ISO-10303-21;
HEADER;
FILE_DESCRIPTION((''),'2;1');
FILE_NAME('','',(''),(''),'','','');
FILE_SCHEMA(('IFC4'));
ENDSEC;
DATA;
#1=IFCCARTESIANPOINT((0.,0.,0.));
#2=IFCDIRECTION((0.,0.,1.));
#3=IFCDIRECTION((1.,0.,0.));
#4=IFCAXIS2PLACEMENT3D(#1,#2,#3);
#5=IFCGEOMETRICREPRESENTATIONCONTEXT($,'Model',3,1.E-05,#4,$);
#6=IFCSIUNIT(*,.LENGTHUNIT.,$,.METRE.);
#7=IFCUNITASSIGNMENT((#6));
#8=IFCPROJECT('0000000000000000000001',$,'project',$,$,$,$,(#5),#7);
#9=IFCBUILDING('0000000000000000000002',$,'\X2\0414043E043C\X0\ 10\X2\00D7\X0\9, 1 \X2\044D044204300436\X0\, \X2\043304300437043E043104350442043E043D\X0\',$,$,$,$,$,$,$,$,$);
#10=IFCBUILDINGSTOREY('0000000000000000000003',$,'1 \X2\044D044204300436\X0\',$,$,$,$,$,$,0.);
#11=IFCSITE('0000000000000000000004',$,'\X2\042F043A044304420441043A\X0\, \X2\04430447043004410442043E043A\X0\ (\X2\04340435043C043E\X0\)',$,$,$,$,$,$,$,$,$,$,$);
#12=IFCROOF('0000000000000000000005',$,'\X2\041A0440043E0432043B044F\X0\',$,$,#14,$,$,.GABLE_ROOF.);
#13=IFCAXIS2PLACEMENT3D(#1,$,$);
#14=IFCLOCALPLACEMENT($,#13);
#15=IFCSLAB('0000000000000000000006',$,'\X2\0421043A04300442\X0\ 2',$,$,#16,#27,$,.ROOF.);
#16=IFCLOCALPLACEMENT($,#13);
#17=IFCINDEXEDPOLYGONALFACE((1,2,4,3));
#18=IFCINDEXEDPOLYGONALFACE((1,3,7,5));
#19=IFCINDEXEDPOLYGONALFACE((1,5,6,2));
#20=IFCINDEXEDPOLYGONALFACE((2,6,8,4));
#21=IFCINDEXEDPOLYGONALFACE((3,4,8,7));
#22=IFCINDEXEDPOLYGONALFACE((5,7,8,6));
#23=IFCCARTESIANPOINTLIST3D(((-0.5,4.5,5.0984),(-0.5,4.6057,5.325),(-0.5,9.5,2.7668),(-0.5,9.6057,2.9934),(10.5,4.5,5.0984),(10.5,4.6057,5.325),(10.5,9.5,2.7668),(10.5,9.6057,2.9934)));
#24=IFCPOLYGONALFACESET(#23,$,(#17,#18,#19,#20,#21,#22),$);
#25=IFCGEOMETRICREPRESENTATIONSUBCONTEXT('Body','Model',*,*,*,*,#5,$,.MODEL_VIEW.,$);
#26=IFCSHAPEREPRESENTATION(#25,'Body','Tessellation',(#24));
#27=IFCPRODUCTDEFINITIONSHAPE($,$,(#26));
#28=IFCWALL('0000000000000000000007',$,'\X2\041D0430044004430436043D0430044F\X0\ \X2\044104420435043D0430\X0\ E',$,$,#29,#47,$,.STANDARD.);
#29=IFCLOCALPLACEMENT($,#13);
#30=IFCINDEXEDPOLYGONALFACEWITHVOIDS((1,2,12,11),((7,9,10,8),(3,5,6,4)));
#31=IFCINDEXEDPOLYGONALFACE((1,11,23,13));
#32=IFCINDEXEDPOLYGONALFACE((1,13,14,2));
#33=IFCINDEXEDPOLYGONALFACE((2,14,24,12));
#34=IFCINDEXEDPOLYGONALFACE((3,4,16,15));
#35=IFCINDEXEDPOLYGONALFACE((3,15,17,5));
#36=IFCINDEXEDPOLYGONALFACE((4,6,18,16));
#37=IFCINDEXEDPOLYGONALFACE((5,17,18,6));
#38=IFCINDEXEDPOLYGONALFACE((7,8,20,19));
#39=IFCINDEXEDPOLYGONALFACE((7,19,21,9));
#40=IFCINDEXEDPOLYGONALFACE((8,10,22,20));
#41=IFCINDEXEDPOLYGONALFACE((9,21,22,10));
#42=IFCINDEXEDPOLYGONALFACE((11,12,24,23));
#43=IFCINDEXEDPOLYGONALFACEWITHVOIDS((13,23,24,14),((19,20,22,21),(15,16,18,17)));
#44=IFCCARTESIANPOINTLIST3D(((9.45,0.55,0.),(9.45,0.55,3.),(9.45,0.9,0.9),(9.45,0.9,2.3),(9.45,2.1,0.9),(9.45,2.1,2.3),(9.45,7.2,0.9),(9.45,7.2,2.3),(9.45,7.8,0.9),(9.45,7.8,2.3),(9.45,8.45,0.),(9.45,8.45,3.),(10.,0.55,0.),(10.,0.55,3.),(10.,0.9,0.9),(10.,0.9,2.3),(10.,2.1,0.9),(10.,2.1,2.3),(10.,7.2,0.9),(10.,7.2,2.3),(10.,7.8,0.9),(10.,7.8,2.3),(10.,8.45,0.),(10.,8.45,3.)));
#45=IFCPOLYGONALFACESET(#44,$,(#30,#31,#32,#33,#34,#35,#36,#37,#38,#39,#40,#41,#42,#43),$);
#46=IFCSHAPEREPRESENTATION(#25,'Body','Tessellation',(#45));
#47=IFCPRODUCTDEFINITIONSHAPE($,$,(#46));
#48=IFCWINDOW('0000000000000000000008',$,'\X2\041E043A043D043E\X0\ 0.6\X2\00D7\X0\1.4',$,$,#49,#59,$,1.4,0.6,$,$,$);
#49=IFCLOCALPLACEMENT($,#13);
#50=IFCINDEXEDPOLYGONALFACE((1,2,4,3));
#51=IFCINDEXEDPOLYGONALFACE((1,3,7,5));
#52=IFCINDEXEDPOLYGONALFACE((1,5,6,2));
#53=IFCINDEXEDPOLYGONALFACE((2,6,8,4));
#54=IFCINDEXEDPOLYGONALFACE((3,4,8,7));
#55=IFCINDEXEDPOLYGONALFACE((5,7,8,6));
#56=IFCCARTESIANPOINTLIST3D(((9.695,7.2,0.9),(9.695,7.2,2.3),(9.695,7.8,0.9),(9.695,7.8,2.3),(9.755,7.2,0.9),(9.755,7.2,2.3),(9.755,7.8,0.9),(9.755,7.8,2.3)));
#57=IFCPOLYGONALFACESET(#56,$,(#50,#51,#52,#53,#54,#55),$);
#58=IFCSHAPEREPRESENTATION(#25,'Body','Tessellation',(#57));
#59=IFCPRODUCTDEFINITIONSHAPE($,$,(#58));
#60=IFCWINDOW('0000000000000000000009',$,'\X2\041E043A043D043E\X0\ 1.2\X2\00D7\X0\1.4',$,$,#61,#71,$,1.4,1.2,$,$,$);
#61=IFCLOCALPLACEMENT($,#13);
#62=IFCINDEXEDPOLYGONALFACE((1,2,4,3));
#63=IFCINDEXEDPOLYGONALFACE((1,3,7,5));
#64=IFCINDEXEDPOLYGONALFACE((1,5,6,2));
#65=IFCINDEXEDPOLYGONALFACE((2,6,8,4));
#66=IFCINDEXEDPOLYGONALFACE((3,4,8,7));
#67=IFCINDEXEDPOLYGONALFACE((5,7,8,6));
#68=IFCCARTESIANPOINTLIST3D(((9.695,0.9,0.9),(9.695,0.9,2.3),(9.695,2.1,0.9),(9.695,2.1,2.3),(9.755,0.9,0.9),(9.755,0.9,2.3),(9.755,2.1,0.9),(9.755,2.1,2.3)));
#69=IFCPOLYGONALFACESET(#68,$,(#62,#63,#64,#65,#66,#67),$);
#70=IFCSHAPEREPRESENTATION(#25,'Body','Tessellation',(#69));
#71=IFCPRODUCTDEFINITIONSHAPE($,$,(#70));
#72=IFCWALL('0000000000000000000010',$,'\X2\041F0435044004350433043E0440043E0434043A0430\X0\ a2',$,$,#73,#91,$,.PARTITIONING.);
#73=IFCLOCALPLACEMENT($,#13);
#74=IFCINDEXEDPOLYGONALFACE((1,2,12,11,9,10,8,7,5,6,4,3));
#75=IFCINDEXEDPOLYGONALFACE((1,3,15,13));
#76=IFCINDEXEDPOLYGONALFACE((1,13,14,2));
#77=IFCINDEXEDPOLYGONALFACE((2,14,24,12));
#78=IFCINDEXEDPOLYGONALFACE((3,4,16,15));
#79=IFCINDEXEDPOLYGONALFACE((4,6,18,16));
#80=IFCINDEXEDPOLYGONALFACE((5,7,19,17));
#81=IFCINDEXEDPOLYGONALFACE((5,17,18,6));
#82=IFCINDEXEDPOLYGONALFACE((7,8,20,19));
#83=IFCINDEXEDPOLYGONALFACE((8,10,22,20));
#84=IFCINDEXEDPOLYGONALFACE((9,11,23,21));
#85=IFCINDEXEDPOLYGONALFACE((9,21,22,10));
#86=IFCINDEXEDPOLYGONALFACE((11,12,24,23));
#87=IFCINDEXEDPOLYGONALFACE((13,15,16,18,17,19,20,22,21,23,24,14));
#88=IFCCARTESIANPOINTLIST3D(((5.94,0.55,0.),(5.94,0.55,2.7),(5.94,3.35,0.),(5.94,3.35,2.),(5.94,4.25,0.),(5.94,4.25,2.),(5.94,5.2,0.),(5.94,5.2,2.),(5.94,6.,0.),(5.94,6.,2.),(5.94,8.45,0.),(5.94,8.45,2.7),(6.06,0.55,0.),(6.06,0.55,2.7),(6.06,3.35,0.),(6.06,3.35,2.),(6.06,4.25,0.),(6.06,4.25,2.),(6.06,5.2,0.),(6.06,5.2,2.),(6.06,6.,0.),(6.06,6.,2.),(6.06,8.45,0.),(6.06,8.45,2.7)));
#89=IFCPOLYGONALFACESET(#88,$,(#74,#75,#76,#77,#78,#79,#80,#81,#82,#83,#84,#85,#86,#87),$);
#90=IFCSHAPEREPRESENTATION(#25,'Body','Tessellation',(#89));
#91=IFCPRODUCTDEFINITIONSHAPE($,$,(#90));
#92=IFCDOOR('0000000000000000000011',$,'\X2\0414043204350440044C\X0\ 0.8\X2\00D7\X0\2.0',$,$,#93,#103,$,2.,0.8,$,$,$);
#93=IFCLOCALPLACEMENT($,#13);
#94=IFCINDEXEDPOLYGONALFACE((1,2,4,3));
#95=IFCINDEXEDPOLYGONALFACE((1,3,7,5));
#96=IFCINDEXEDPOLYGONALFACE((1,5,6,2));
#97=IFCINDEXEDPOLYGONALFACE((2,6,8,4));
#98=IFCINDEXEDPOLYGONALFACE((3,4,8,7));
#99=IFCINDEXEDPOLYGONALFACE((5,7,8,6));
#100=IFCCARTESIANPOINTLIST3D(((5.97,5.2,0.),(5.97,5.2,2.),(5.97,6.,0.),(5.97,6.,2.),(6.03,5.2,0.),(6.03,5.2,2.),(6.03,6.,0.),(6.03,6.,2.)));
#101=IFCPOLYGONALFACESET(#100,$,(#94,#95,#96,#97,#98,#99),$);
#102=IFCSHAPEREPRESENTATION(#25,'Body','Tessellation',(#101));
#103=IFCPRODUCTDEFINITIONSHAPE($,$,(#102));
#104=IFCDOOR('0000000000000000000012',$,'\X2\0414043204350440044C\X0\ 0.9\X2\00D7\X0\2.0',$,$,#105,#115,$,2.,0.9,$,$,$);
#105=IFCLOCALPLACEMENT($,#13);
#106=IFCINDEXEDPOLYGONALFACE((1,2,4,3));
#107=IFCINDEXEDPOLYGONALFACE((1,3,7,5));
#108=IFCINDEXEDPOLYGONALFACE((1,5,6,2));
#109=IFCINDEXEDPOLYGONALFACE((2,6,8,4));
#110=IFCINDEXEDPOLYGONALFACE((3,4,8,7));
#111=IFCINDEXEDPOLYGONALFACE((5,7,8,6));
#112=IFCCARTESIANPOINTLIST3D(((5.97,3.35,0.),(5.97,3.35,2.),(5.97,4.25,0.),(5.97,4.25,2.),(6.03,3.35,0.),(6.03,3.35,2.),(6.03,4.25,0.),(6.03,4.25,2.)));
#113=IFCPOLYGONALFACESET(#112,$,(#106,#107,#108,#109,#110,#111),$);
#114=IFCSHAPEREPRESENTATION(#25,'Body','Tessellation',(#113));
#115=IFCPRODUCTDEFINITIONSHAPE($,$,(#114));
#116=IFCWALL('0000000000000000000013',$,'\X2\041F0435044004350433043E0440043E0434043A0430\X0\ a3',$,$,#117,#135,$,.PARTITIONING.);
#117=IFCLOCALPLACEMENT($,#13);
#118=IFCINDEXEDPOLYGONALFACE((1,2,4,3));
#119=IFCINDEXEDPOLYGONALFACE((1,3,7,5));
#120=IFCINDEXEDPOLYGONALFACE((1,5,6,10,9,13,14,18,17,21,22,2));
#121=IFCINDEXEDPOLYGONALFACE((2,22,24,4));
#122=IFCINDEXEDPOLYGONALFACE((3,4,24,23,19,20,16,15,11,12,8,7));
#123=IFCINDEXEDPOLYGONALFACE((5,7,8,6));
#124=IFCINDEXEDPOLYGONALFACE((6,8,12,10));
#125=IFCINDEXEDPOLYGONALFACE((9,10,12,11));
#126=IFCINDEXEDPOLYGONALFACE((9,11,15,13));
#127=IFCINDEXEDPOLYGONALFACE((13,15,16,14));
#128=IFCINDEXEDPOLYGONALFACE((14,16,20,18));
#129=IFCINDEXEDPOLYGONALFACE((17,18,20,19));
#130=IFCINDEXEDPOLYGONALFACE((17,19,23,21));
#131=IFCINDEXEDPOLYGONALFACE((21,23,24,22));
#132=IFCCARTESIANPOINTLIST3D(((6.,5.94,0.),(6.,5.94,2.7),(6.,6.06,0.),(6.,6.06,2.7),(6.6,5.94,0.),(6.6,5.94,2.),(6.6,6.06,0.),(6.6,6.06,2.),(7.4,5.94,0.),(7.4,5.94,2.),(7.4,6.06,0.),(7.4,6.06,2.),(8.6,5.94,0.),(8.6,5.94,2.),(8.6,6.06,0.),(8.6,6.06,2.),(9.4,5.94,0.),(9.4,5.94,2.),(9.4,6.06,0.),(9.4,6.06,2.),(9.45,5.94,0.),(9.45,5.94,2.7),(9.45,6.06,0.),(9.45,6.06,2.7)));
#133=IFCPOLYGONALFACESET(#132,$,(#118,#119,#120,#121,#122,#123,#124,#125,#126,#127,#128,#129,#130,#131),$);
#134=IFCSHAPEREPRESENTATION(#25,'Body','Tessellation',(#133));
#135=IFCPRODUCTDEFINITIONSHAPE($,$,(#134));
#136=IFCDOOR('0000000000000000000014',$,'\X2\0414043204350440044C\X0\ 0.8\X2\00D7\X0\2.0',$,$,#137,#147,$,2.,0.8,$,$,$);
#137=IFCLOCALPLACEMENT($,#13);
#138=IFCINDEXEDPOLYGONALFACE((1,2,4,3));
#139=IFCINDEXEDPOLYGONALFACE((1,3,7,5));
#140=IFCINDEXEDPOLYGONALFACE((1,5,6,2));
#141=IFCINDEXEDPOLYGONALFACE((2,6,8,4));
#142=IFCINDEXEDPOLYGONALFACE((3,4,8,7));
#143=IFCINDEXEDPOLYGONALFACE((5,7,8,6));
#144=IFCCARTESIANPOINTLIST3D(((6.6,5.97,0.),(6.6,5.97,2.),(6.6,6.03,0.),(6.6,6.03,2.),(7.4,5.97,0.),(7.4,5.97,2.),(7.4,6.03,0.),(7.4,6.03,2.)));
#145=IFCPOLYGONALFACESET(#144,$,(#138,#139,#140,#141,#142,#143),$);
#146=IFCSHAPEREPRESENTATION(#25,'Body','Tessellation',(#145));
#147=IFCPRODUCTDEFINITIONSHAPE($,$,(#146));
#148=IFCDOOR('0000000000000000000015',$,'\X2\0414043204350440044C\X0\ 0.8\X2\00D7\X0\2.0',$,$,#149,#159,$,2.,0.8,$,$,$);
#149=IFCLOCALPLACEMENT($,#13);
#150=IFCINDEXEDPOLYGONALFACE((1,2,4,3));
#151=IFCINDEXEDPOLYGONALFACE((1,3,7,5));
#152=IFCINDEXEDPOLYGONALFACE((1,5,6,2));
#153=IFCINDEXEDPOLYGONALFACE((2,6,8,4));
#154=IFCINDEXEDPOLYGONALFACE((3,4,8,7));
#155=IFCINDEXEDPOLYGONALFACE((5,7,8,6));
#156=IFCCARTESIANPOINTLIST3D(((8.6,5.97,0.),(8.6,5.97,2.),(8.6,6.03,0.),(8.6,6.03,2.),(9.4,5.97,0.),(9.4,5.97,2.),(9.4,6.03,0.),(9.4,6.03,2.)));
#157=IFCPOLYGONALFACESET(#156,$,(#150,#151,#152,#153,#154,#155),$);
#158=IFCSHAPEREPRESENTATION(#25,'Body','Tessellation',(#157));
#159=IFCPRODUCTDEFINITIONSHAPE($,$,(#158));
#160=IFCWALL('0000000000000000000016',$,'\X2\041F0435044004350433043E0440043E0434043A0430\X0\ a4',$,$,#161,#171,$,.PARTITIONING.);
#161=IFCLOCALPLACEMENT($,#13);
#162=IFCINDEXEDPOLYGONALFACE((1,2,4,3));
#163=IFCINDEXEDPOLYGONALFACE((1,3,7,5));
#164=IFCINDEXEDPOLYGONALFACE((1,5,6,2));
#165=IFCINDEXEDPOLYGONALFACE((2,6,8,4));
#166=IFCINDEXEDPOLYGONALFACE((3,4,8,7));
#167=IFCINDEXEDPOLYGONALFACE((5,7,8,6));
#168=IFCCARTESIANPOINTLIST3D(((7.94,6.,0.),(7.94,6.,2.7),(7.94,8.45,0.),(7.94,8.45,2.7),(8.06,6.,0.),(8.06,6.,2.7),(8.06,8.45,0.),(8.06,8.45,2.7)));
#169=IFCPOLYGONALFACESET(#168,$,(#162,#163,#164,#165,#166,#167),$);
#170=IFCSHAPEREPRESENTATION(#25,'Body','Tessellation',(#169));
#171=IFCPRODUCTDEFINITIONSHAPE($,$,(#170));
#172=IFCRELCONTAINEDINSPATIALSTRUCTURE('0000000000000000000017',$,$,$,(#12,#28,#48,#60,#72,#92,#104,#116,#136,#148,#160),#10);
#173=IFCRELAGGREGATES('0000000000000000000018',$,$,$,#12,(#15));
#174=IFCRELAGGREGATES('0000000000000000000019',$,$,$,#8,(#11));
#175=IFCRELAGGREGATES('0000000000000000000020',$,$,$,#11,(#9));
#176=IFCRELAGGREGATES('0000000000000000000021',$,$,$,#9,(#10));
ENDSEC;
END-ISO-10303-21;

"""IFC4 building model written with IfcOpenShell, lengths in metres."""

from ifc_helpers import new_model, si_unit, frame, origin_with_axes, place, context, subcontext, project, spatial, indexed_curve, outline, extrude, element, fill, aggregate, save


model = new_model("IFC4")

# Units and contexts
model_context = context("Model", 3, precision=1e-05, world=origin_with_axes())
body_context = subcontext(model_context, "Body", "Model", "MODEL_VIEW")
ifc_project = project(units=[si_unit("LENGTHUNIT", "METRE")], contexts=[model_context])

# Site, building, storey
site = spatial("IfcSite", under=ifc_project, Name="Якутск, участок (демо)")
building = spatial("IfcBuilding", under=site, Name="Дом 10×9, 1 этаж, газобетон")
storey = spatial("IfcBuildingStorey", under=building, Name="1 этаж", Elevation=0.0)

# Roof, slab
roof = element("IfcRoof", 1, inside=storey, Name="Кровля", PredefinedType="GABLE_ROOF")
slab_placement = place(None, frame((10.5, 9.5, 2.7668), z_axis=(0.0, 0.422618, 0.906308), x_axis=(-1.0, 0.0, 0.0)))
slab = element("IfcSlab", 2, at=slab_placement, Name="Скат 2", PredefinedType="ROOF", context=body_context, shape_type="SweptSolid", body=[
    extrude(outline(indexed_curve([(0.0, 0.0), (11.0, 0.0), (11.0, 5.5169), (0.0, 5.5169)])), None, (0.0, 0.0, 1.0), 0.25),
])
aggregate(roof, [slab])

# Wall, openings, windows
wall_1_placement = place(None, frame((10.0, 0.55, 0.0), z_axis=(0.0, 0.0, 1.0), x_axis=(0.0, 1.0, 0.0)))
wall_1 = element("IfcWall", 3, at=wall_1_placement, inside=storey, Name="Наружная стена E", PredefinedType="STANDARD", context=body_context, shape_type="SweptSolid", body=[
    extrude(outline(indexed_curve([(0.0, 0.0), (0.0, 0.55), (7.9, 0.55), (7.9, 0.0), (0.0, 0.0)], self_intersect=False)), origin_with_axes(), (0.0, 0.0, 1.0), 3.0),
])
opening_1_placement = place(wall_1_placement, frame((6.65, 0.6, 0.9), z_axis=(0.0, 0.0, 1.0), x_axis=(0.0, -1.0, 0.0)))
opening_1 = element("IfcOpeningElement", 4, at=opening_1_placement, cuts=wall_1, context=body_context, shape_type="SweptSolid", body=[
    extrude(outline(indexed_curve([(0.0, 0.0), (0.0, 0.6), (0.65, 0.6), (0.65, 0.0), (0.0, 0.0)], self_intersect=False)), origin_with_axes(), (0.0, 0.0, 1.0), 1.4),
])
opening_2_placement = place(wall_1_placement, frame((0.35, -0.05, 0.9), z_axis=(0.0, 0.0, 1.0), x_axis=(1.0, 0.0, 0.0)))
opening_2 = element("IfcOpeningElement", 5, at=opening_2_placement, cuts=wall_1, context=body_context, shape_type="SweptSolid", body=[
    extrude(outline(indexed_curve([(0.0, 0.0), (0.0, 0.65), (1.2, 0.65), (1.2, 0.0), (0.0, 0.0)], self_intersect=False)), origin_with_axes(), (0.0, 0.0, 1.0), 1.4),
])
window_1_placement = place(opening_1_placement, frame((0.355, 0.0, 0.0), z_axis=(0.0, 0.0, 1.0), x_axis=(0.0, 1.0, 0.0)))
window_1 = element("IfcWindow", 6, at=window_1_placement, inside=storey, Name="Окно 0.6×1.4", OverallHeight=1.4, OverallWidth=0.6, context=body_context, shape_type="SweptSolid", body=[
    extrude(outline(indexed_curve([(0.0, 0.0), (0.0, 0.06), (0.6, 0.06), (0.6, 0.0), (0.0, 0.0)], self_intersect=False)), origin_with_axes(), (0.0, 0.0, 1.0), 1.4),
])
fill(opening_1, window_1)
window_2_placement = place(opening_2_placement, frame((0.0, 0.295, 0.0), z_axis=(0.0, 0.0, 1.0), x_axis=(1.0, 0.0, 0.0)))
window_2 = element("IfcWindow", 7, at=window_2_placement, inside=storey, Name="Окно 1.2×1.4", OverallHeight=1.4, OverallWidth=1.2, context=body_context, shape_type="SweptSolid", body=[
    extrude(outline(indexed_curve([(0.0, 0.0), (0.0, 0.06), (1.2, 0.06), (1.2, 0.0), (0.0, 0.0)], self_intersect=False)), origin_with_axes(), (0.0, 0.0, 1.0), 1.4),
])
fill(opening_2, window_2)

# Walls, openings, doors
wall_2_placement = place(None, frame((6.06, 0.55, 0.0), z_axis=(0.0, 0.0, 1.0), x_axis=(0.0, 1.0, 0.0)))
wall_2 = element("IfcWall", 8, at=wall_2_placement, inside=storey, Name="Перегородка a2", PredefinedType="PARTITIONING", context=body_context, shape_type="SweptSolid", body=[
    extrude(outline(indexed_curve([(0.0, 0.0), (0.0, 0.12), (7.9, 0.12), (7.9, 0.0), (0.0, 0.0)], self_intersect=False)), origin_with_axes(), (0.0, 0.0, 1.0), 2.7),
])
opening_3_placement = place(wall_2_placement, frame((4.65, -0.05, 0.0), z_axis=(0.0, 0.0, 1.0), x_axis=(1.0, 0.0, 0.0)))
opening_3 = element("IfcOpeningElement", 9, at=opening_3_placement, cuts=wall_2, context=body_context, shape_type="SweptSolid", body=[
    extrude(outline(indexed_curve([(0.0, 0.0), (0.0, 0.22), (0.8, 0.22), (0.8, 0.0), (0.0, 0.0)], self_intersect=False)), origin_with_axes(), (0.0, 0.0, 1.0), 2.0),
])
opening_4_placement = place(wall_2_placement, frame((2.8, -0.05, 0.0), z_axis=(0.0, 0.0, 1.0), x_axis=(1.0, 0.0, 0.0)))
opening_4 = element("IfcOpeningElement", 10, at=opening_4_placement, cuts=wall_2, context=body_context, shape_type="SweptSolid", body=[
    extrude(outline(indexed_curve([(0.0, 0.0), (0.0, 0.22), (0.9, 0.22), (0.9, 0.0), (0.0, 0.0)], self_intersect=False)), origin_with_axes(), (0.0, 0.0, 1.0), 2.0),
])
door_1_placement = place(opening_3_placement, frame((0.0, 0.08, 0.0), z_axis=(0.0, 0.0, 1.0), x_axis=(1.0, 0.0, 0.0)))
door_1 = element("IfcDoor", 11, at=door_1_placement, inside=storey, Name="Дверь 0.8×2.0", OverallHeight=2.0, OverallWidth=0.8, context=body_context, shape_type="SweptSolid", body=[
    extrude(outline(indexed_curve([(0.0, 0.0), (0.0, 0.06), (0.8, 0.06), (0.8, 0.0), (0.0, 0.0)], self_intersect=False)), origin_with_axes(), (0.0, 0.0, 1.0), 2.0),
])
fill(opening_3, door_1)
door_2_placement = place(opening_4_placement, frame((0.0, 0.08, 0.0), z_axis=(0.0, 0.0, 1.0), x_axis=(1.0, 0.0, 0.0)))
door_2 = element("IfcDoor", 12, at=door_2_placement, inside=storey, Name="Дверь 0.9×2.0", OverallHeight=2.0, OverallWidth=0.9, context=body_context, shape_type="SweptSolid", body=[
    extrude(outline(indexed_curve([(0.0, 0.0), (0.0, 0.06), (0.9, 0.06), (0.9, 0.0), (0.0, 0.0)], self_intersect=False)), origin_with_axes(), (0.0, 0.0, 1.0), 2.0),
])
fill(opening_4, door_2)
wall_3_placement = place(None, frame((6.0, 5.94, 0.0), z_axis=(0.0, 0.0, 1.0), x_axis=(1.0, 0.0, 0.0)))
wall_3 = element("IfcWall", 13, at=wall_3_placement, inside=storey, Name="Перегородка a3", PredefinedType="PARTITIONING", context=body_context, shape_type="SweptSolid", body=[
    extrude(outline(indexed_curve([(0.0, 0.0), (0.0, 0.12), (3.45, 0.12), (3.45, 0.0), (0.0, 0.0)], self_intersect=False)), origin_with_axes(), (0.0, 0.0, 1.0), 2.7),
])
opening_5_placement = place(wall_3_placement, frame((0.6, -0.05, 0.0), z_axis=(0.0, 0.0, 1.0), x_axis=(1.0, 0.0, 0.0)))
opening_5 = element("IfcOpeningElement", 14, at=opening_5_placement, cuts=wall_3, context=body_context, shape_type="SweptSolid", body=[
    extrude(outline(indexed_curve([(0.0, 0.0), (0.0, 0.22), (0.8, 0.22), (0.8, 0.0), (0.0, 0.0)], self_intersect=False)), origin_with_axes(), (0.0, 0.0, 1.0), 2.0),
])
opening_6_placement = place(wall_3_placement, frame((2.6, -0.05, 0.0), z_axis=(0.0, 0.0, 1.0), x_axis=(1.0, 0.0, 0.0)))
opening_6 = element("IfcOpeningElement", 15, at=opening_6_placement, cuts=wall_3, context=body_context, shape_type="SweptSolid", body=[
    extrude(outline(indexed_curve([(0.0, 0.0), (0.0, 0.22), (0.8, 0.22), (0.8, 0.0), (0.0, 0.0)], self_intersect=False)), origin_with_axes(), (0.0, 0.0, 1.0), 2.0),
])
door_3_placement = place(opening_5_placement, frame((0.0, 0.08, 0.0), z_axis=(0.0, 0.0, 1.0), x_axis=(1.0, 0.0, 0.0)))
door_3 = element("IfcDoor", 16, at=door_3_placement, inside=storey, Name="Дверь 0.8×2.0", OverallHeight=2.0, OverallWidth=0.8, context=body_context, shape_type="SweptSolid", body=[
    extrude(outline(indexed_curve([(0.0, 0.0), (0.0, 0.06), (0.8, 0.06), (0.8, 0.0), (0.0, 0.0)], self_intersect=False)), origin_with_axes(), (0.0, 0.0, 1.0), 2.0),
])
fill(opening_5, door_3)
door_4_placement = place(opening_6_placement, frame((0.0, 0.08, 0.0), z_axis=(0.0, 0.0, 1.0), x_axis=(1.0, 0.0, 0.0)))
door_4 = element("IfcDoor", 17, at=door_4_placement, inside=storey, Name="Дверь 0.8×2.0", OverallHeight=2.0, OverallWidth=0.8, context=body_context, shape_type="SweptSolid", body=[
    extrude(outline(indexed_curve([(0.0, 0.0), (0.0, 0.06), (0.8, 0.06), (0.8, 0.0), (0.0, 0.0)], self_intersect=False)), origin_with_axes(), (0.0, 0.0, 1.0), 2.0),
])
fill(opening_6, door_4)

# Wall
wall_4_placement = place(None, frame((8.06, 6.0, 0.0), z_axis=(0.0, 0.0, 1.0), x_axis=(0.0, 1.0, 0.0)))
element("IfcWall", 18, at=wall_4_placement, inside=storey, Name="Перегородка a4", PredefinedType="PARTITIONING", context=body_context, shape_type="SweptSolid", body=[
    extrude(outline(indexed_curve([(0.0, 0.0), (0.0, 0.12), (2.45, 0.12), (2.45, 0.0), (0.0, 0.0)], self_intersect=False)), origin_with_axes(), (0.0, 0.0, 1.0), 2.7),
])

save(model, "model.ifc")
